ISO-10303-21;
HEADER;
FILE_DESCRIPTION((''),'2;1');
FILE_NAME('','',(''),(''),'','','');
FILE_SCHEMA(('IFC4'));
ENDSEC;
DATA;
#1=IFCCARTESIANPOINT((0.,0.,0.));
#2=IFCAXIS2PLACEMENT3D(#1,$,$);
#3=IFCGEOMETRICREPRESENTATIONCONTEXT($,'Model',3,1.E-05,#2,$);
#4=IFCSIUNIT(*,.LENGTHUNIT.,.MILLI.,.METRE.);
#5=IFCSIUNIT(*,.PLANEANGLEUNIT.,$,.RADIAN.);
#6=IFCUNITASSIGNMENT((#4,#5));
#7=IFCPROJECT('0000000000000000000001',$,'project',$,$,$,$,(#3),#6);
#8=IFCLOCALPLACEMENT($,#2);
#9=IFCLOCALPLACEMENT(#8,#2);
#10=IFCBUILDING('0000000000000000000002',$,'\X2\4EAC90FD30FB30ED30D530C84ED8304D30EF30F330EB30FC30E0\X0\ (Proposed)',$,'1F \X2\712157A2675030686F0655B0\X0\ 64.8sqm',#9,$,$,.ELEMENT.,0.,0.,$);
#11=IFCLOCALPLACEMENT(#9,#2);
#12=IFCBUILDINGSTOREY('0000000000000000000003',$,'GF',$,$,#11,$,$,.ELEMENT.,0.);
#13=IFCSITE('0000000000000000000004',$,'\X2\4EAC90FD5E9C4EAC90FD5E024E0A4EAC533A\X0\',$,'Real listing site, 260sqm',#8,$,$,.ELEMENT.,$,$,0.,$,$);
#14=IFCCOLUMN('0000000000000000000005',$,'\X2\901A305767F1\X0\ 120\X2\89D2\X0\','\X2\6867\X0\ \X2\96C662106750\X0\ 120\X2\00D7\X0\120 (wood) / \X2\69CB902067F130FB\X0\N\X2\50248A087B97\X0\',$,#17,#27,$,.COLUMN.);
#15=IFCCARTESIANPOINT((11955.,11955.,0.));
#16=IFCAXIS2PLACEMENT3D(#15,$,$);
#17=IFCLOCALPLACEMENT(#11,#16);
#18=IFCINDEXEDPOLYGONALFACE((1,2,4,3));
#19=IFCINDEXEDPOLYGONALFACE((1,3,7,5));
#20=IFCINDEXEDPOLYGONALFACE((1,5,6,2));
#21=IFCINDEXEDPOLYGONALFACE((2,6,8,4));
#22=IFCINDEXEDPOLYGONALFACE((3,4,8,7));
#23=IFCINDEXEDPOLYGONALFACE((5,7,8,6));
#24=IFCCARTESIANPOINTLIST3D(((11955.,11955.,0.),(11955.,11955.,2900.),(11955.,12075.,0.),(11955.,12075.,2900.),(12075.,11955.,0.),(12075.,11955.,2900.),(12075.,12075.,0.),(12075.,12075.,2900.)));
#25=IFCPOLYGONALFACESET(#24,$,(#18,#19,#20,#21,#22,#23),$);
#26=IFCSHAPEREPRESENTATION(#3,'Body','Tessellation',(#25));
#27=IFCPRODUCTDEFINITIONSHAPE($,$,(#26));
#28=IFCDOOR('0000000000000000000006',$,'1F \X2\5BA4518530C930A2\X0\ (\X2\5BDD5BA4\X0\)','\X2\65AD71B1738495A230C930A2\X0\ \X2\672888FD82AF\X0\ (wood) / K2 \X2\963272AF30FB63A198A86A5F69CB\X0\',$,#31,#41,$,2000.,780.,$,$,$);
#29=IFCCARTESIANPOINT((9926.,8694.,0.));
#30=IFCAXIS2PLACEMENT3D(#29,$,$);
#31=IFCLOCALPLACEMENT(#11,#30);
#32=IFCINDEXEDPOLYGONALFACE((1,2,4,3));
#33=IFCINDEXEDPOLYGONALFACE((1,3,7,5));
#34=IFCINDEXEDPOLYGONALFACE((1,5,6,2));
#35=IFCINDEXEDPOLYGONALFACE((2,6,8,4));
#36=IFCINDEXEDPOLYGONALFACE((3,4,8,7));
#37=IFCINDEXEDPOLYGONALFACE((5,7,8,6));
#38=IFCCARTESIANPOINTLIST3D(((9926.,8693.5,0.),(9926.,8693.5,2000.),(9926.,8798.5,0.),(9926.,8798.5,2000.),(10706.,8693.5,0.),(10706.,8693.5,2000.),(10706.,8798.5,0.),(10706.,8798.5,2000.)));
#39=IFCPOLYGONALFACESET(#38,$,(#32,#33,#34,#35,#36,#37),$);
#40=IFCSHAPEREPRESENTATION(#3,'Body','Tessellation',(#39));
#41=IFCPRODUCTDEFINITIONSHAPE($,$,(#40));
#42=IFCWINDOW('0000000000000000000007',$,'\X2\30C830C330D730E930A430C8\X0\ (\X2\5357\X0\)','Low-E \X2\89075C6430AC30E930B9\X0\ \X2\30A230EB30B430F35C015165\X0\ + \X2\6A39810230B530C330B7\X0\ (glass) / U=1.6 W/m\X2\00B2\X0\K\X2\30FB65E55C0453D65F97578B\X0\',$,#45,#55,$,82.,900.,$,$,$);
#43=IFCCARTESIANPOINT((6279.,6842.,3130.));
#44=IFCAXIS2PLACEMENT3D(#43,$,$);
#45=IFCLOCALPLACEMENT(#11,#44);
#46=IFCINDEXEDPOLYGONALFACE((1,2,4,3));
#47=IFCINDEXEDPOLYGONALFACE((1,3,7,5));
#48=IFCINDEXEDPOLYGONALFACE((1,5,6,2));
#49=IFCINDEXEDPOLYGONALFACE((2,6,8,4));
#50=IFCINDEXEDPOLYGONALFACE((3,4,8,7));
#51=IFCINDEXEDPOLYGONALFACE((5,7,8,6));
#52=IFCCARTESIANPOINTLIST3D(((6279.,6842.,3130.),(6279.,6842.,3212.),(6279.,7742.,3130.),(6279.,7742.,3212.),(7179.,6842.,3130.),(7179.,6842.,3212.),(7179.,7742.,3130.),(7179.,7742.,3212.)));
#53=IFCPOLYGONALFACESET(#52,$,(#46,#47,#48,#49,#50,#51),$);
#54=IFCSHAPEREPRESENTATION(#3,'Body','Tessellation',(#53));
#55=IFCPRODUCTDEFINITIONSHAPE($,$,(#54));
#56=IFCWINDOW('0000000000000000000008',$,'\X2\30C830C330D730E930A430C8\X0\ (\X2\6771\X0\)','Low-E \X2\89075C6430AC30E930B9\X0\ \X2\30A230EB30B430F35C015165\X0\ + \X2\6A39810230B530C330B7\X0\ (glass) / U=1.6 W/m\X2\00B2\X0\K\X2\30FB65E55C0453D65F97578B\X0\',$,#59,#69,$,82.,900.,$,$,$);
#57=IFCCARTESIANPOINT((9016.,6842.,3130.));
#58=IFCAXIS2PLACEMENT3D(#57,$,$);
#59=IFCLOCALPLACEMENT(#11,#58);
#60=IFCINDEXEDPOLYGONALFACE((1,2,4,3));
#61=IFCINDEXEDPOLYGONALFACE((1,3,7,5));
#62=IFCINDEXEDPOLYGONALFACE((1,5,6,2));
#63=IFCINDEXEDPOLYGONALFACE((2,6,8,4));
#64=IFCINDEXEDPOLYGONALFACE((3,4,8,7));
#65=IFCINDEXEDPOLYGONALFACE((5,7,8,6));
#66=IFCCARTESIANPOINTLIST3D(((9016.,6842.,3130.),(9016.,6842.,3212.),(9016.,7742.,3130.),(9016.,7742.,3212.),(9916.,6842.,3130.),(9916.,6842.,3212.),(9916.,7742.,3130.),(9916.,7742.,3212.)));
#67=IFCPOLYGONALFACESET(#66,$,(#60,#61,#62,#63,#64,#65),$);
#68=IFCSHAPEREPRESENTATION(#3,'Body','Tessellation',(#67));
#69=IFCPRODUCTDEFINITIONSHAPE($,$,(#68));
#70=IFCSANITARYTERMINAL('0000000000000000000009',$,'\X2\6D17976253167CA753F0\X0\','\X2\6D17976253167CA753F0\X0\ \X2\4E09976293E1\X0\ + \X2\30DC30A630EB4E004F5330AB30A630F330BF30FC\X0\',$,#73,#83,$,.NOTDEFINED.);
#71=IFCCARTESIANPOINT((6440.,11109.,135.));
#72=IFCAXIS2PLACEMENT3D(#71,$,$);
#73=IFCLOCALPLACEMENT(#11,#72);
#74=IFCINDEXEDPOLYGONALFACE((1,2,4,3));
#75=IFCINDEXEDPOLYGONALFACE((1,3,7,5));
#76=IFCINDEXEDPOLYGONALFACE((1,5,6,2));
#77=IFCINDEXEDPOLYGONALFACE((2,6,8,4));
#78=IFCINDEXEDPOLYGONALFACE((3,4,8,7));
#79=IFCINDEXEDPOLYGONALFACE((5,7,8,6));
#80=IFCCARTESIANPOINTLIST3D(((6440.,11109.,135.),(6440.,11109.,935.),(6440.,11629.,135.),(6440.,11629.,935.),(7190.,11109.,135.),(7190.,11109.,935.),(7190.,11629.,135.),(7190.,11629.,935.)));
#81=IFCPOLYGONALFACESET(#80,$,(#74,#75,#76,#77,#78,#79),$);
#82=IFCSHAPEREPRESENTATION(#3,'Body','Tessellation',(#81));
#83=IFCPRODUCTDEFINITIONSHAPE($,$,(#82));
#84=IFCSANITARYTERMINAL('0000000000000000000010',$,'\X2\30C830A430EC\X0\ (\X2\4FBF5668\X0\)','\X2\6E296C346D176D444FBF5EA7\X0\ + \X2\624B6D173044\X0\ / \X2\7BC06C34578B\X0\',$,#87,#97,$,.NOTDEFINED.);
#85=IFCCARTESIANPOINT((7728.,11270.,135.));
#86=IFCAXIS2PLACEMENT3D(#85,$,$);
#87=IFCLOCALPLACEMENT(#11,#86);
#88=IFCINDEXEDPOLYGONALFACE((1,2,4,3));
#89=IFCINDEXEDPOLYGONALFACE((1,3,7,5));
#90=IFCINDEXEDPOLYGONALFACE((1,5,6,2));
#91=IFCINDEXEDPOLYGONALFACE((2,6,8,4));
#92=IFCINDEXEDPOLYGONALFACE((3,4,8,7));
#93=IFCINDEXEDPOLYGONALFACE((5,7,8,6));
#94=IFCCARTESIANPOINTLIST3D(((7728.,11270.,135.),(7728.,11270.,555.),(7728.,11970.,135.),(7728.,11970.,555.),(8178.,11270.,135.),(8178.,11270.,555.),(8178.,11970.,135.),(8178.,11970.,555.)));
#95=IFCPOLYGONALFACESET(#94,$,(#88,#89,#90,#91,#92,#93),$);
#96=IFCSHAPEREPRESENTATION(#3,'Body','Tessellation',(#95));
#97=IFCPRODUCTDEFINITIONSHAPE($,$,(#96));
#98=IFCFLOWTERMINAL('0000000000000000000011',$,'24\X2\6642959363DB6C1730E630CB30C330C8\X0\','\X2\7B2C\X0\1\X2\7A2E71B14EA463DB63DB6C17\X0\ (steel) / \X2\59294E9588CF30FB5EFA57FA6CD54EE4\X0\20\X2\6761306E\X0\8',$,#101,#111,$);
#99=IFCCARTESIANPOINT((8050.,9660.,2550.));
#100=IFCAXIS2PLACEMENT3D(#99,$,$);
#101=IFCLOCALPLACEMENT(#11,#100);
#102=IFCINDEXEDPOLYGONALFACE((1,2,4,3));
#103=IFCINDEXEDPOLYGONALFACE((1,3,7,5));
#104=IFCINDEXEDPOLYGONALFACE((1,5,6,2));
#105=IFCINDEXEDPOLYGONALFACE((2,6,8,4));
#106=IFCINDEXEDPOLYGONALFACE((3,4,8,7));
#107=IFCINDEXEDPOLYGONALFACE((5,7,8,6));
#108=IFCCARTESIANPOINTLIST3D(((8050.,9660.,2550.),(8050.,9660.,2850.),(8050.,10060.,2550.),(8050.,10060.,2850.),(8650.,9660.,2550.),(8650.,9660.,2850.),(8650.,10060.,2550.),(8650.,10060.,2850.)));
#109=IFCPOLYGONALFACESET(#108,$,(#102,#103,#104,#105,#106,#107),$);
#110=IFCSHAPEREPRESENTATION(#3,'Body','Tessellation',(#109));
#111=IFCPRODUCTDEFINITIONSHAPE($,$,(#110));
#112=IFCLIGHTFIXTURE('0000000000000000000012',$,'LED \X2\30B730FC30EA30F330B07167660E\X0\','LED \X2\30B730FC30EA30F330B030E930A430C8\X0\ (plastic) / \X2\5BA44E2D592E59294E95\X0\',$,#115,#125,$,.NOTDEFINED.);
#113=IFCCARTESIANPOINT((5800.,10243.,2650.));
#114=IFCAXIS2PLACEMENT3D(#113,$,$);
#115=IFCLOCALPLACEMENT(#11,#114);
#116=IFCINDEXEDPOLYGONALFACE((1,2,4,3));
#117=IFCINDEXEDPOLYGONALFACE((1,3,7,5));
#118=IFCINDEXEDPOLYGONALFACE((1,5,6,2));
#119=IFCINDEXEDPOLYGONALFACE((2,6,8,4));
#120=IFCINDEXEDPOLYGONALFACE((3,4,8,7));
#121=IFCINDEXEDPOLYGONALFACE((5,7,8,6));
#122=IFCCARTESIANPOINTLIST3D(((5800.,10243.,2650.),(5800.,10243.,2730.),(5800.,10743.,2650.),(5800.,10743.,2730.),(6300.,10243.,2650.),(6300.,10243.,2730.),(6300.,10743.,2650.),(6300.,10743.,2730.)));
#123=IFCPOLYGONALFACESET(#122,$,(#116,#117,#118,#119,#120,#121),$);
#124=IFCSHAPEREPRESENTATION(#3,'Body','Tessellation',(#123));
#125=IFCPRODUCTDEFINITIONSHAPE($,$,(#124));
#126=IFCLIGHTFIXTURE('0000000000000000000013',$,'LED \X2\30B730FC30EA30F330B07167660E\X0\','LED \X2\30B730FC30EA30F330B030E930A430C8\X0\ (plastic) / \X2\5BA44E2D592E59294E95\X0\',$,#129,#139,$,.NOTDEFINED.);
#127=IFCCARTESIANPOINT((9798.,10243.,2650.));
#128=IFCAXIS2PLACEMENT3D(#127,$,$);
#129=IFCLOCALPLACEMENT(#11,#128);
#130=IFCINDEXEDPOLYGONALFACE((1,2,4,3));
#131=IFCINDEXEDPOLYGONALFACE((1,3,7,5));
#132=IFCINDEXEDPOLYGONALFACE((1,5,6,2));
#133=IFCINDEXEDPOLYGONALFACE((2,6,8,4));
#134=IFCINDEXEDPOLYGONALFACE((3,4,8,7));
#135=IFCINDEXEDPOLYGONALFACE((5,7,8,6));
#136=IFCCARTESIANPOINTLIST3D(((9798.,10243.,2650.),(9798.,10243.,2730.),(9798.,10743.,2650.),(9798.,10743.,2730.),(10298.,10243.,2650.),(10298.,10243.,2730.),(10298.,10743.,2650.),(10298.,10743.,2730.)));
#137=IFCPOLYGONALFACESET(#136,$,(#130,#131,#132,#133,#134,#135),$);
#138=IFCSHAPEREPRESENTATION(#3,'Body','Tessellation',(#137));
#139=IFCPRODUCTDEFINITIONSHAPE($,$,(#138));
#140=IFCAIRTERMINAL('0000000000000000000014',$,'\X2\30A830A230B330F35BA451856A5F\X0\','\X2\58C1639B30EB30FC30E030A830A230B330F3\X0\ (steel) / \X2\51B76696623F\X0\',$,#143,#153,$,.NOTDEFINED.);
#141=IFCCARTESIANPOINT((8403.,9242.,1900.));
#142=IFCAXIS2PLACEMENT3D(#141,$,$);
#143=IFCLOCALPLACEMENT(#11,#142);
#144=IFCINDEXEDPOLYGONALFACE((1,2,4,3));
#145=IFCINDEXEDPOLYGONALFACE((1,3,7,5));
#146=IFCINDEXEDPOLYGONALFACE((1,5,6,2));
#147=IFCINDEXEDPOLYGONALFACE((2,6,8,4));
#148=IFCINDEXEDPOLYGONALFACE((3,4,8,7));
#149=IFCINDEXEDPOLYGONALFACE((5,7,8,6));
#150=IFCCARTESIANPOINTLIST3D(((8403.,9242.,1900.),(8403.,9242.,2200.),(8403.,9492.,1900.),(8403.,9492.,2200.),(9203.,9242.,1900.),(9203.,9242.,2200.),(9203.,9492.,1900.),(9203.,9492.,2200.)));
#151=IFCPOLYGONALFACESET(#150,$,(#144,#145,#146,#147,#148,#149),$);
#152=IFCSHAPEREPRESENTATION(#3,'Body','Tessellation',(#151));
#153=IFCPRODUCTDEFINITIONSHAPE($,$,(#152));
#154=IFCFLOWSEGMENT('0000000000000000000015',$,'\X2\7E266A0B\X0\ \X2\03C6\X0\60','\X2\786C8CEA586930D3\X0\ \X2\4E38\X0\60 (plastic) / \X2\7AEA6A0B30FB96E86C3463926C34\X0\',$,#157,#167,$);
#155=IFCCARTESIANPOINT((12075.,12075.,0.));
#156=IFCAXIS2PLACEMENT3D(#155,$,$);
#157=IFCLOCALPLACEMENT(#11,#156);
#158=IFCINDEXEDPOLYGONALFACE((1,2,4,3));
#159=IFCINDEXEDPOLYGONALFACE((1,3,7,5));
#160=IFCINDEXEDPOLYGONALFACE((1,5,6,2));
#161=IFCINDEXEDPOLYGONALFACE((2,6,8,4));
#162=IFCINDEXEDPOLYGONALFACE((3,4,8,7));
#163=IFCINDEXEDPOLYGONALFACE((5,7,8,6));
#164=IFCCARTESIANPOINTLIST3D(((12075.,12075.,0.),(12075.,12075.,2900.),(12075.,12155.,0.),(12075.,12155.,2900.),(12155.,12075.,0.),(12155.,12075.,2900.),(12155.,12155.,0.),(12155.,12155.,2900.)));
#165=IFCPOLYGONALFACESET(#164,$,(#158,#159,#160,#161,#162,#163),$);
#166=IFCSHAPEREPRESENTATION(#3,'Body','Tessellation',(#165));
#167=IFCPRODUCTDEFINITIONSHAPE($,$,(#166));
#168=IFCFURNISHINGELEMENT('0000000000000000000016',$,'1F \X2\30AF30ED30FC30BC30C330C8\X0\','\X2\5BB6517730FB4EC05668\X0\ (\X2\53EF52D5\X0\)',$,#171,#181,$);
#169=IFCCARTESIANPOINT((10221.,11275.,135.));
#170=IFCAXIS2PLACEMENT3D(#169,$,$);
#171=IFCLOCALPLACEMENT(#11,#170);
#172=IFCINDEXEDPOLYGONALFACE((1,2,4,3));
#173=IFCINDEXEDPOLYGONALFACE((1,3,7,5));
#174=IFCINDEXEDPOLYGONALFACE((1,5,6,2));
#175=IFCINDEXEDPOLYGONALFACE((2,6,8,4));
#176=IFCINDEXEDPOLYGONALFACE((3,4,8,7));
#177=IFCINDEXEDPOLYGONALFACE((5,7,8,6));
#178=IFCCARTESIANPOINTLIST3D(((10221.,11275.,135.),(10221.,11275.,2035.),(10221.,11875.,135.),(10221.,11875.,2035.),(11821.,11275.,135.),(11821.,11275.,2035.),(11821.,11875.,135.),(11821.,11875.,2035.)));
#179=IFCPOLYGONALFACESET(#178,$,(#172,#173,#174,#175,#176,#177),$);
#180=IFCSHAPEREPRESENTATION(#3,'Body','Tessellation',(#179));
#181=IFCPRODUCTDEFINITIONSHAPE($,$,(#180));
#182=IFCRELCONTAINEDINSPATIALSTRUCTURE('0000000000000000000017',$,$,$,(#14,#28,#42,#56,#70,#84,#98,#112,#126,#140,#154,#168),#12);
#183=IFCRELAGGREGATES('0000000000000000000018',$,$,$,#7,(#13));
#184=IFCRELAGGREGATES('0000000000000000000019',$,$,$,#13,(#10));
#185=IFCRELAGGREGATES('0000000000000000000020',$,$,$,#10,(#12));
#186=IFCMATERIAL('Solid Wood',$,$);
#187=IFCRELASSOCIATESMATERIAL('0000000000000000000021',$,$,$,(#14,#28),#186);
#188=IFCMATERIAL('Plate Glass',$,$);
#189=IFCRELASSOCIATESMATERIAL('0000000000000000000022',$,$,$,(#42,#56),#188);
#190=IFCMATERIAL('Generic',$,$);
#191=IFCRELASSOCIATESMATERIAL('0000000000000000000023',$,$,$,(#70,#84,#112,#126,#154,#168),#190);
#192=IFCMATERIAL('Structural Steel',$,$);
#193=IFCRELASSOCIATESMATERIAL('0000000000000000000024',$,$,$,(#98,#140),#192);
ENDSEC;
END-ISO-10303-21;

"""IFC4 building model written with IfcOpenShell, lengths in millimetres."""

from ifc_helpers import new_model, si_unit, frame, frame_2d, origin, place, context, project, spatial, rectangle, extrude, material, element, save


model = new_model("IFC4")

# Units and contexts
model_context = context("Model", 3, precision=1e-05, world=origin())
ifc_project = project(units=[si_unit("LENGTHUNIT", "METRE", prefix="MILLI"), si_unit("PLANEANGLEUNIT", "RADIAN")], contexts=[model_context])

# Site, building, storey
site_placement = place(None, origin())
site = spatial("IfcSite", under=ifc_project, at=site_placement, Name="京都府京都市上京区", ObjectType="Real listing site, 260sqm", CompositionType="ELEMENT", RefElevation=0.0)
building_placement = place(site_placement, origin())
building = spatial("IfcBuilding", under=site, at=building_placement, Name="京都・ロフト付きワンルーム (Proposed)", ObjectType="1F 無垢材と漆喰 64.8sqm", CompositionType="ELEMENT", ElevationOfRefHeight=0.0, ElevationOfTerrain=0.0)
storey_placement = place(building_placement, origin())
storey = spatial("IfcBuildingStorey", under=building, at=storey_placement, Name="GF", CompositionType="ELEMENT", Elevation=0.0)

# Column
ifc_material_1 = material(Name="Solid Wood")
column_1_placement = place(storey_placement, frame((11955.0, 11955.0, 0.0)))
element("IfcColumn", 1, at=column_1_placement, inside=storey, material=ifc_material_1, Name="通し柱 120角", Description="桧 集成材 120×120 (wood) / 構造柱・N値計算", PredefinedType="COLUMN", context=model_context, shape_type="SweptSolid", body=[
    extrude(rectangle(XDim=120.0, YDim=120.0, at=frame_2d((60.0, 60.0))), frame((11955.0, 11955.0, 0.0)), (0.0, 0.0, 1.0), 2900.0),
])

# Door
door_placement = place(storey_placement, frame((9926.0, 8694.0, 0.0)))
element("IfcDoor", 2, at=door_placement, inside=storey, material=ifc_material_1, Name="1F 室内ドア (寝室)", Description="断熱玄関ドア 木製芯 (wood) / K2 防犯・採風機構", OverallHeight=2000.0, OverallWidth=780.0, context=model_context, shape_type="SweptSolid", body=[
    extrude(rectangle(XDim=780.0, YDim=105.0, at=frame_2d((390.0, 52.0))), frame((9926.0, 8694.0, 0.0)), (0.0, 0.0, 1.0), 2000.0),
])

# Windows
ifc_material_2 = material(Name="Plate Glass")
window_1_placement = place(storey_placement, frame((6279.0, 6842.0, 3130.0)))
element("IfcWindow", 3, at=window_1_placement, inside=storey, material=ifc_material_2, Name="トップライト (南)", Description="Low-E 複層ガラス アルゴン封入 + 樹脂サッシ (glass) / U=1.6 W/m²K・日射取得型", OverallHeight=82.0, OverallWidth=900.0, context=model_context, shape_type="SweptSolid", body=[
    extrude(rectangle(XDim=900.0, YDim=900.0, at=frame_2d((450.0, 450.0))), frame((6279.0, 6842.0, 3130.0)), (0.0, 0.0, 1.0), 82.0),
])
window_2_placement = place(storey_placement, frame((9016.0, 6842.0, 3130.0)))
element("IfcWindow", 4, at=window_2_placement, inside=storey, material=ifc_material_2, Name="トップライト (東)", Description="Low-E 複層ガラス アルゴン封入 + 樹脂サッシ (glass) / U=1.6 W/m²K・日射取得型", OverallHeight=82.0, OverallWidth=900.0, context=model_context, shape_type="SweptSolid", body=[
    extrude(rectangle(XDim=900.0, YDim=900.0, at=frame_2d((450.0, 450.0))), frame((9016.0, 6842.0, 3130.0)), (0.0, 0.0, 1.0), 82.0),
])

# Sanitary terminals
ifc_material_3 = material(Name="Generic")
sanitary_terminal_1_placement = place(storey_placement, frame((6440.0, 11109.0, 135.0)))
element("IfcSanitaryTerminal", 5, at=sanitary_terminal_1_placement, inside=storey, material=ifc_material_3, Name="洗面化粧台", Description="洗面化粧台 三面鏡 + ボウル一体カウンター", PredefinedType="NOTDEFINED", context=model_context, shape_type="SweptSolid", body=[
    extrude(rectangle(XDim=750.0, YDim=520.0, at=frame_2d((375.0, 260.0))), frame((6440.0, 11109.0, 135.0)), (0.0, 0.0, 1.0), 800.0),
])
sanitary_terminal_2_placement = place(storey_placement, frame((7728.0, 11270.0, 135.0)))
element("IfcSanitaryTerminal", 6, at=sanitary_terminal_2_placement, inside=storey, material=ifc_material_3, Name="トイレ (便器)", Description="温水洗浄便座 + 手洗い / 節水型", PredefinedType="NOTDEFINED", context=model_context, shape_type="SweptSolid", body=[
    extrude(rectangle(XDim=450.0, YDim=700.0, at=frame_2d((225.0, 350.0))), frame((7728.0, 11270.0, 135.0)), (0.0, 0.0, 1.0), 420.0),
])

# Flow terminal
ifc_material_4 = material(Name="Structural Steel")
flow_terminal_placement = place(storey_placement, frame((8050.0, 9660.0, 2550.0)))
element("IfcFlowTerminal", 7, at=flow_terminal_placement, inside=storey, material=ifc_material_4, Name="24時間換気ユニット", Description="第1種熱交換換気 (steel) / 天井裏・建基法令20条の8", context=model_context, shape_type="SweptSolid", body=[
    extrude(rectangle(XDim=600.0, YDim=400.0, at=frame_2d((300.0, 200.0))), frame((8050.0, 9660.0, 2550.0)), (0.0, 0.0, 1.0), 300.0),
])

# Light fixtures
light_fixture_1_placement = place(storey_placement, frame((5800.0, 10243.0, 2650.0)))
element("IfcLightFixture", 8, at=light_fixture_1_placement, inside=storey, material=ifc_material_3, Name="LED シーリング照明", Description="LED シーリングライト (plastic) / 室中央天井", PredefinedType="NOTDEFINED", context=model_context, shape_type="SweptSolid", body=[
    extrude(rectangle(XDim=500.0, YDim=500.0, at=frame_2d((250.0, 250.0))), frame((5800.0, 10243.0, 2650.0)), (0.0, 0.0, 1.0), 80.0),
])
light_fixture_2_placement = place(storey_placement, frame((9798.0, 10243.0, 2650.0)))
element("IfcLightFixture", 9, at=light_fixture_2_placement, inside=storey, material=ifc_material_3, Name="LED シーリング照明", Description="LED シーリングライト (plastic) / 室中央天井", PredefinedType="NOTDEFINED", context=model_context, shape_type="SweptSolid", body=[
    extrude(rectangle(XDim=500.0, YDim=500.0, at=frame_2d((250.0, 250.0))), frame((9798.0, 10243.0, 2650.0)), (0.0, 0.0, 1.0), 80.0),
])

# Air terminal
air_terminal_placement = place(storey_placement, frame((8403.0, 9242.0, 1900.0)))
element("IfcAirTerminal", 10, at=air_terminal_placement, inside=storey, material=ifc_material_4, Name="エアコン室内機", Description="壁掛ルームエアコン (steel) / 冷暖房", PredefinedType="NOTDEFINED", context=model_context, shape_type="SweptSolid", body=[
    extrude(rectangle(XDim=800.0, YDim=250.0, at=frame_2d((400.0, 125.0))), frame((8403.0, 9242.0, 1900.0)), (0.0, 0.0, 1.0), 300.0),
])

# Flow segment
flow_segment_placement = place(storey_placement, frame((12075.0, 12075.0, 0.0)))
element("IfcFlowSegment", 11, at=flow_segment_placement, inside=storey, material=ifc_material_3, Name="縦樋 φ60", Description="硬質塩ビ 丸60 (plastic) / 竪樋・雨水排水", context=model_context, shape_type="SweptSolid", body=[
    extrude(rectangle(XDim=80.0, YDim=80.0, at=frame_2d((40.0, 40.0))), frame((12075.0, 12075.0, 0.0)), (0.0, 0.0, 1.0), 2900.0),
])

# Furnishing element
furnishing_placement = place(storey_placement, frame((10221.0, 11275.0, 135.0)))
element("IfcFurnishingElement", 12, at=furnishing_placement, inside=storey, material=ifc_material_3, Name="1F クローゼット", Description="家具・什器 (可動)", context=model_context, shape_type="SweptSolid", body=[
    extrude(rectangle(XDim=1600.0, YDim=600.0, at=frame_2d((800.0, 300.0))), frame((10221.0, 11275.0, 135.0)), (0.0, 0.0, 1.0), 1900.0),
])

save(model, "model.ifc")
